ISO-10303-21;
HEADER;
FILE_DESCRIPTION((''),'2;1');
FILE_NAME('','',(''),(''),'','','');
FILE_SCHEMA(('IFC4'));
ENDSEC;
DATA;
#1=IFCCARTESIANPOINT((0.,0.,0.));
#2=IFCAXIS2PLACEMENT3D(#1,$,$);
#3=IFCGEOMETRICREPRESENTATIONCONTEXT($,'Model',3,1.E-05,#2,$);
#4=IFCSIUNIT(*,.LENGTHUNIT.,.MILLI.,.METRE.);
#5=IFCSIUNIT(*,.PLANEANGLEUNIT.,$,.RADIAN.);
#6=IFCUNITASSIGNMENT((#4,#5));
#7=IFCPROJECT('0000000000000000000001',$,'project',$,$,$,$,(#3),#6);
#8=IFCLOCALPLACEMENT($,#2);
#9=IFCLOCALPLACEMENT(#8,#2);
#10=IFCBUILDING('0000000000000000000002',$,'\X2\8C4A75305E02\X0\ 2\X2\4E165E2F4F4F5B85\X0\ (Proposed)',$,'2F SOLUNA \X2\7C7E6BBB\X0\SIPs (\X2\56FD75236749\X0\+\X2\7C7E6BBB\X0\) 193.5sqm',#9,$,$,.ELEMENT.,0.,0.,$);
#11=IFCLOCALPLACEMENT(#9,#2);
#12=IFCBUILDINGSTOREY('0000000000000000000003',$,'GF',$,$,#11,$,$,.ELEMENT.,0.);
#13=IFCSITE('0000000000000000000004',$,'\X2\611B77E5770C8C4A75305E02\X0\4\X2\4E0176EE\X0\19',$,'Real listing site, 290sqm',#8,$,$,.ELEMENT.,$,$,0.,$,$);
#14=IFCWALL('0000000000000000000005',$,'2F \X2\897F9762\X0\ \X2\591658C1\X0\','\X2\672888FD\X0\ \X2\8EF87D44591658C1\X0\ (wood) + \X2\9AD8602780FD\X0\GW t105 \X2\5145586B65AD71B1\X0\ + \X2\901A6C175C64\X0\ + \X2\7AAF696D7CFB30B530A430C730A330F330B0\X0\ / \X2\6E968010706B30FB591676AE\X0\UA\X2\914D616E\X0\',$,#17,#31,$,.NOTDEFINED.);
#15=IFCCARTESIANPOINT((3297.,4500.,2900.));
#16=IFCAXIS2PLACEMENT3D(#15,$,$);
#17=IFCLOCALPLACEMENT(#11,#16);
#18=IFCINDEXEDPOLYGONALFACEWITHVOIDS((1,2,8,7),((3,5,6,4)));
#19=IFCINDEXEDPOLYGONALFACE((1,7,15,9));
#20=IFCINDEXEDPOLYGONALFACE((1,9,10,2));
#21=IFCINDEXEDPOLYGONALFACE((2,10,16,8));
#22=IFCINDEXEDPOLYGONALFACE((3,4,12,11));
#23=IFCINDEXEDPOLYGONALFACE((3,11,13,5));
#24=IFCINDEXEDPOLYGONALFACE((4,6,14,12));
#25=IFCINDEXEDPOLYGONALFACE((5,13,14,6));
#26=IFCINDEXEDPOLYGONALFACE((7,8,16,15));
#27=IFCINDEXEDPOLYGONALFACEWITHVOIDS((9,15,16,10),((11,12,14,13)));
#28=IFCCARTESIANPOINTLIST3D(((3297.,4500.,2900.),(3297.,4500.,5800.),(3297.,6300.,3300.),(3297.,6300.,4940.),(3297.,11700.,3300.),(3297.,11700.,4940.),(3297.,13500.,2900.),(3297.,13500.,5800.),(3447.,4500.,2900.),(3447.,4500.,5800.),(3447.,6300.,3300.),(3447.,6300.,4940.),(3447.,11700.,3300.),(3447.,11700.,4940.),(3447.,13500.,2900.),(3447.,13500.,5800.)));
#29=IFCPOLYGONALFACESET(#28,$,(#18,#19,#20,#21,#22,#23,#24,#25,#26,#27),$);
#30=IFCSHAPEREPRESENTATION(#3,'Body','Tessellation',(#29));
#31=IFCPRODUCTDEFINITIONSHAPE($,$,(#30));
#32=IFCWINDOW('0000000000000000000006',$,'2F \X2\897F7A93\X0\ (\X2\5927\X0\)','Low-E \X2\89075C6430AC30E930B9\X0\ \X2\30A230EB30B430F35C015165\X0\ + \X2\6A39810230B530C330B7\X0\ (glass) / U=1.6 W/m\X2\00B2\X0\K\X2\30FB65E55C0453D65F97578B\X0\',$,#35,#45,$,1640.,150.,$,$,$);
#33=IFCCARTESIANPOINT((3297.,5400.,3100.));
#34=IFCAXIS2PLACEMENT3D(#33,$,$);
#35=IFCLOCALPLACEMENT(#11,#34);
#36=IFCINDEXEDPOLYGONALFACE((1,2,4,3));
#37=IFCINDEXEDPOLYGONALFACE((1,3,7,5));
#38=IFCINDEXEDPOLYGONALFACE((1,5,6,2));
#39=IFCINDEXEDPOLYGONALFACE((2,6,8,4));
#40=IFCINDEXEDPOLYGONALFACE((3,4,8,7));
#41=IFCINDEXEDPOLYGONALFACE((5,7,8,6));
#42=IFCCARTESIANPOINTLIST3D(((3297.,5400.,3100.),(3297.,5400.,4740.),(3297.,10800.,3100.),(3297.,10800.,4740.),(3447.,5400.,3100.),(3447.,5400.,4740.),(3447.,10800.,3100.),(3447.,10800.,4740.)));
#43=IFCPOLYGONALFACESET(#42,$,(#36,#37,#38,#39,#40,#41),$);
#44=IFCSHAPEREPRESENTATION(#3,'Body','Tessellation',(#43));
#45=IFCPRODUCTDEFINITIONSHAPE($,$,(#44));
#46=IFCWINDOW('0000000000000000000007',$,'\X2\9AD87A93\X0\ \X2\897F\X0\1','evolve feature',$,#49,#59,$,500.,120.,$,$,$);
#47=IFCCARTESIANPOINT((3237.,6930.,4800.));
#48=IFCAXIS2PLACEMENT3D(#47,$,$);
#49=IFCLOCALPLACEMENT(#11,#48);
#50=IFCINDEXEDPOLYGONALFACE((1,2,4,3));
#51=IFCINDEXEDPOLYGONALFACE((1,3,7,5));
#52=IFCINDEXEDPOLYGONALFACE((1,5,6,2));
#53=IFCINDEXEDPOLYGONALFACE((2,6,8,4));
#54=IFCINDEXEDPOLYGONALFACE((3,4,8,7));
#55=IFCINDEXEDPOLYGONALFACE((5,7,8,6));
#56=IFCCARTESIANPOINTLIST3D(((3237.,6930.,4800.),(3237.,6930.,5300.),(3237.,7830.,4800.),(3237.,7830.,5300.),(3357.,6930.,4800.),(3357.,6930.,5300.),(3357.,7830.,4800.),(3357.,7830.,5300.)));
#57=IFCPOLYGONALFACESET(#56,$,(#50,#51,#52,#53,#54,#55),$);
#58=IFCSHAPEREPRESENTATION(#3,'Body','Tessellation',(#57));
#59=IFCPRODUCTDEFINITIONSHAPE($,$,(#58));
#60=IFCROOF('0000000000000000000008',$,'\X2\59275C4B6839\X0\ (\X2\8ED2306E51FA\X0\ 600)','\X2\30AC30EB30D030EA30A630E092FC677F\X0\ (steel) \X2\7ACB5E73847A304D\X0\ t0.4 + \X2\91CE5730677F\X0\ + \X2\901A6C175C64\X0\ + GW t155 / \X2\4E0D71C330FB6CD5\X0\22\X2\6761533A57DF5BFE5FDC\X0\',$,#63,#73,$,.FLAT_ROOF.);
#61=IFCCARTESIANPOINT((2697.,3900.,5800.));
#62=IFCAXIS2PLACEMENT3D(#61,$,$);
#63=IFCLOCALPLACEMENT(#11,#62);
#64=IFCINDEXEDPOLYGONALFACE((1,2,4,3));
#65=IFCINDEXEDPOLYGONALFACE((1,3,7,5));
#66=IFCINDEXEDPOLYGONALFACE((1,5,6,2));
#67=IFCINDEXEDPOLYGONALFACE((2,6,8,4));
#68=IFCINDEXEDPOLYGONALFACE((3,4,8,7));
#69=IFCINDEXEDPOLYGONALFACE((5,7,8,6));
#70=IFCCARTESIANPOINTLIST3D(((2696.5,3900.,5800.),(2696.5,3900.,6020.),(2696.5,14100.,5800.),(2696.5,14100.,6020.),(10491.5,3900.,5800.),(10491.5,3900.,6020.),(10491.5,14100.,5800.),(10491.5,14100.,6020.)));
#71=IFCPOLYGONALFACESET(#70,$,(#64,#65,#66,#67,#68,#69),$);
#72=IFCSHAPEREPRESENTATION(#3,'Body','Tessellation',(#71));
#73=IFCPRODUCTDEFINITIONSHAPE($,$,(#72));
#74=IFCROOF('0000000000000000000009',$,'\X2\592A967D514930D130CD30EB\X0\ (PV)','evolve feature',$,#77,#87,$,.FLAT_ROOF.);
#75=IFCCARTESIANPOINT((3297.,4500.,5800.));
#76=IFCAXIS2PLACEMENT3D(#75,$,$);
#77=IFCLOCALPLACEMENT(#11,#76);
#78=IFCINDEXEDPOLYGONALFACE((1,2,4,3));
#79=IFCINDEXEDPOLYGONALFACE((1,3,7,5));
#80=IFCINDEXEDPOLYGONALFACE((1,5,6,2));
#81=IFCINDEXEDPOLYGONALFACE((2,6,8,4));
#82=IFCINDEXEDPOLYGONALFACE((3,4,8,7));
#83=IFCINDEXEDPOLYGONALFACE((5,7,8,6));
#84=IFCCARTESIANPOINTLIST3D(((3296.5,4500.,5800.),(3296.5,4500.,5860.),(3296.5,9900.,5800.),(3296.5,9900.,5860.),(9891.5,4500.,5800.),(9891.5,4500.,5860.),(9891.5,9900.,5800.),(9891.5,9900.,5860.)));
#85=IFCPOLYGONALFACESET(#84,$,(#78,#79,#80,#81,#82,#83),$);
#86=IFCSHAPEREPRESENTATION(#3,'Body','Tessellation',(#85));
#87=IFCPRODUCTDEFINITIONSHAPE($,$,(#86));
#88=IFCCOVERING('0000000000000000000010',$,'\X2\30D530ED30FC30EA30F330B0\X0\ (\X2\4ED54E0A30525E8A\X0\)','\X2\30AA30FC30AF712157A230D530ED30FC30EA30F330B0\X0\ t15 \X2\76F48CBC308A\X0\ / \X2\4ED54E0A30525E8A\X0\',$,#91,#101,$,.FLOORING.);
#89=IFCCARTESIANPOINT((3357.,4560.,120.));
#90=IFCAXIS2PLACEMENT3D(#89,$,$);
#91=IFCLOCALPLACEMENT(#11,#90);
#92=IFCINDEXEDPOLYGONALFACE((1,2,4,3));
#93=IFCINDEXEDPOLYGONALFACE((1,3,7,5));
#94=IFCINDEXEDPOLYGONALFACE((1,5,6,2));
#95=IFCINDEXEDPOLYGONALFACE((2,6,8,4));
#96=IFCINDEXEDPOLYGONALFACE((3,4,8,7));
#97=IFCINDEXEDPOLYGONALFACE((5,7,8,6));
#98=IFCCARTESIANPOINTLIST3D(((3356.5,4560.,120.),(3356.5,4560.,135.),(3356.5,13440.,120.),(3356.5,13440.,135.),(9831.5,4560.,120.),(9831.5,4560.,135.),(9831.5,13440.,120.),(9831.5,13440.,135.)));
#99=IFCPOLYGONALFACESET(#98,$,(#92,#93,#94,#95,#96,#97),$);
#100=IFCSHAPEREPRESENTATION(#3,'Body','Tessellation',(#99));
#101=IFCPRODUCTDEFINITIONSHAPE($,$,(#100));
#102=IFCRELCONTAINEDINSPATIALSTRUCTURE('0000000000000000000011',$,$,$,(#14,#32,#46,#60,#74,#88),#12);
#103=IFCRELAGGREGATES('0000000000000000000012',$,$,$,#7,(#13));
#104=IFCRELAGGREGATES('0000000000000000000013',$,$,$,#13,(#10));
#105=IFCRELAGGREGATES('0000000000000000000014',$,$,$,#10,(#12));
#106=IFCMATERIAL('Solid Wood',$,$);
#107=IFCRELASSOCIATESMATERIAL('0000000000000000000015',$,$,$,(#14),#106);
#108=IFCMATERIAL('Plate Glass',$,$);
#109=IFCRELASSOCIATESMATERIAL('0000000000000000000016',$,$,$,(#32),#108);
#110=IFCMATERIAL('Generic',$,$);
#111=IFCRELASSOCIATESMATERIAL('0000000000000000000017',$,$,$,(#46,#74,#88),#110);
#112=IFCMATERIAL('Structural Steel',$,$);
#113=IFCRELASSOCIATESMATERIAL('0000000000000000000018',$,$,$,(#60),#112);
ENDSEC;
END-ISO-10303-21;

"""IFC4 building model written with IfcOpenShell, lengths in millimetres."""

from ifc_helpers import new_model, si_unit, frame, frame_2d, origin, place, context, project, spatial, rectangle, extrude, material, element, fill, save


model = new_model("IFC4")

# Units and contexts
model_context = context("Model", 3, precision=1e-05, world=origin())
ifc_project = project(units=[si_unit("LENGTHUNIT", "METRE", prefix="MILLI"), si_unit("PLANEANGLEUNIT", "RADIAN")], contexts=[model_context])

# Site, building, storey
site_placement = place(None, origin())
site = spatial("IfcSite", under=ifc_project, at=site_placement, Name="愛知県豊田市4丁目19", ObjectType="Real listing site, 290sqm", CompositionType="ELEMENT", RefElevation=0.0)
building_placement = place(site_placement, origin())
building = spatial("IfcBuilding", under=site, at=building_placement, Name="豊田市 2世帯住宅 (Proposed)", ObjectType="2F SOLUNA 籾殻SIPs (国産杉+籾殻) 193.5sqm", CompositionType="ELEMENT", ElevationOfRefHeight=0.0, ElevationOfTerrain=0.0)
storey_placement = place(building_placement, origin())
storey = spatial("IfcBuildingStorey", under=building, at=storey_placement, Name="GF", CompositionType="ELEMENT", Elevation=0.0)

# Shared definitions
ifc_material_1 = material(Name="Solid Wood")

# Shared definitions
ifc_material_2 = material(Name="Plate Glass")
ifc_material_3 = material(Name="Generic")

# Wall, openings, windows
wall_1_placement = place(storey_placement, frame((3297.0, 4500.0, 2900.0)))
wall_1 = element("IfcWall", 1, at=wall_1_placement, inside=storey, material=ifc_material_1, Name="2F 西面 外壁", Description="木製 軸組外壁 (wood) + 高性能GW t105 充填断熱 + 通気層 + 窯業系サイディング / 準耐火・外皮UA配慮", PredefinedType="NOTDEFINED", context=model_context, shape_type="SweptSolid", body=[
    extrude(rectangle(XDim=150.0, YDim=9000.0, at=frame_2d((75.0, 4500.0))), frame((3297.0, 4500.0, 2900.0)), (0.0, 0.0, 1.0), 2900.0),
])
opening_1_placement = place(storey_placement, frame((3297.0, 5400.0, 3100.0)))
opening_1 = element("IfcOpeningElement", 2, at=opening_1_placement, cuts=wall_1, PredefinedType="NOTDEFINED", context=model_context, shape_type="SweptSolid", body=[
    extrude(rectangle(XDim=150.0, YDim=5400.0, at=frame_2d((75.0, 2700.0))), frame((3297.0, 5400.0, 3100.0)), (0.0, 0.0, 1.0), 1640.0),
])
opening_2_placement = place(storey_placement, frame((3237.0, 6930.0, 4800.0)))
opening_2 = element("IfcOpeningElement", 3, at=opening_2_placement, cuts=wall_1, PredefinedType="NOTDEFINED", context=model_context, shape_type="SweptSolid", body=[
    extrude(rectangle(XDim=120.0, YDim=900.0, at=frame_2d((60.0, 450.0))), frame((3237.0, 6930.0, 4800.0)), (0.0, 0.0, 1.0), 500.0),
])
window_1_placement = place(storey_placement, frame((3297.0, 5400.0, 3100.0)))
window_1 = element("IfcWindow", 4, at=window_1_placement, inside=storey, material=ifc_material_2, Name="2F 西窓 (大)", Description="Low-E 複層ガラス アルゴン封入 + 樹脂サッシ (glass) / U=1.6 W/m²K・日射取得型", OverallHeight=1640.0, OverallWidth=150.0, context=model_context, shape_type="SweptSolid", body=[
    extrude(rectangle(XDim=150.0, YDim=5400.0, at=frame_2d((75.0, 2700.0))), frame((3297.0, 5400.0, 3100.0)), (0.0, 0.0, 1.0), 1640.0),
])
fill(opening_1, window_1)
window_2_placement = place(storey_placement, frame((3237.0, 6930.0, 4800.0)))
window_2 = element("IfcWindow", 5, at=window_2_placement, inside=storey, material=ifc_material_3, Name="高窓 西1", Description="evolve feature", OverallHeight=500.0, OverallWidth=120.0, context=model_context, shape_type="SweptSolid", body=[
    extrude(rectangle(XDim=120.0, YDim=900.0, at=frame_2d((60.0, 450.0))), frame((3237.0, 6930.0, 4800.0)), (0.0, 0.0, 1.0), 500.0),
])
fill(opening_2, window_2)

# Roofs
ifc_material_4 = material(Name="Structural Steel")
roof_1_placement = place(storey_placement, frame((2697.0, 3900.0, 5800.0)))
element("IfcRoof", 6, at=roof_1_placement, inside=storey, material=ifc_material_4, Name="大屋根 (軒の出 600)", Description="ガルバリウム鋼板 (steel) 立平葺き t0.4 + 野地板 + 通気層 + GW t155 / 不燃・法22条区域対応", PredefinedType="FLAT_ROOF", context=model_context, shape_type="SweptSolid", body=[
    extrude(rectangle(XDim=7795.0, YDim=10200.0, at=frame_2d((3897.0, 5100.0))), frame((2697.0, 3900.0, 5800.0)), (0.0, 0.0, 1.0), 220.0),
])
roof_2_placement = place(storey_placement, frame((3297.0, 4500.0, 5800.0)))
element("IfcRoof", 7, at=roof_2_placement, inside=storey, material=ifc_material_3, Name="太陽光パネル (PV)", Description="evolve feature", PredefinedType="FLAT_ROOF", context=model_context, shape_type="SweptSolid", body=[
    extrude(rectangle(XDim=6595.0, YDim=5400.0, at=frame_2d((3297.0, 2700.0))), frame((3297.0, 4500.0, 5800.0)), (0.0, 0.0, 1.0), 60.0),
])

# Covering
covering_placement = place(storey_placement, frame((3357.0, 4560.0, 120.0)))
element("IfcCovering", 8, at=covering_placement, inside=storey, material=ifc_material_3, Name="フローリング (仕上げ床)", Description="オーク無垢フローリング t15 直貼り / 仕上げ床", PredefinedType="FLOORING", context=model_context, shape_type="SweptSolid", body=[
    extrude(rectangle(XDim=6475.0, YDim=8880.0, at=frame_2d((3237.0, 4440.0))), frame((3357.0, 4560.0, 120.0)), (0.0, 0.0, 1.0), 15.0),
])

save(model, "model.ifc")
